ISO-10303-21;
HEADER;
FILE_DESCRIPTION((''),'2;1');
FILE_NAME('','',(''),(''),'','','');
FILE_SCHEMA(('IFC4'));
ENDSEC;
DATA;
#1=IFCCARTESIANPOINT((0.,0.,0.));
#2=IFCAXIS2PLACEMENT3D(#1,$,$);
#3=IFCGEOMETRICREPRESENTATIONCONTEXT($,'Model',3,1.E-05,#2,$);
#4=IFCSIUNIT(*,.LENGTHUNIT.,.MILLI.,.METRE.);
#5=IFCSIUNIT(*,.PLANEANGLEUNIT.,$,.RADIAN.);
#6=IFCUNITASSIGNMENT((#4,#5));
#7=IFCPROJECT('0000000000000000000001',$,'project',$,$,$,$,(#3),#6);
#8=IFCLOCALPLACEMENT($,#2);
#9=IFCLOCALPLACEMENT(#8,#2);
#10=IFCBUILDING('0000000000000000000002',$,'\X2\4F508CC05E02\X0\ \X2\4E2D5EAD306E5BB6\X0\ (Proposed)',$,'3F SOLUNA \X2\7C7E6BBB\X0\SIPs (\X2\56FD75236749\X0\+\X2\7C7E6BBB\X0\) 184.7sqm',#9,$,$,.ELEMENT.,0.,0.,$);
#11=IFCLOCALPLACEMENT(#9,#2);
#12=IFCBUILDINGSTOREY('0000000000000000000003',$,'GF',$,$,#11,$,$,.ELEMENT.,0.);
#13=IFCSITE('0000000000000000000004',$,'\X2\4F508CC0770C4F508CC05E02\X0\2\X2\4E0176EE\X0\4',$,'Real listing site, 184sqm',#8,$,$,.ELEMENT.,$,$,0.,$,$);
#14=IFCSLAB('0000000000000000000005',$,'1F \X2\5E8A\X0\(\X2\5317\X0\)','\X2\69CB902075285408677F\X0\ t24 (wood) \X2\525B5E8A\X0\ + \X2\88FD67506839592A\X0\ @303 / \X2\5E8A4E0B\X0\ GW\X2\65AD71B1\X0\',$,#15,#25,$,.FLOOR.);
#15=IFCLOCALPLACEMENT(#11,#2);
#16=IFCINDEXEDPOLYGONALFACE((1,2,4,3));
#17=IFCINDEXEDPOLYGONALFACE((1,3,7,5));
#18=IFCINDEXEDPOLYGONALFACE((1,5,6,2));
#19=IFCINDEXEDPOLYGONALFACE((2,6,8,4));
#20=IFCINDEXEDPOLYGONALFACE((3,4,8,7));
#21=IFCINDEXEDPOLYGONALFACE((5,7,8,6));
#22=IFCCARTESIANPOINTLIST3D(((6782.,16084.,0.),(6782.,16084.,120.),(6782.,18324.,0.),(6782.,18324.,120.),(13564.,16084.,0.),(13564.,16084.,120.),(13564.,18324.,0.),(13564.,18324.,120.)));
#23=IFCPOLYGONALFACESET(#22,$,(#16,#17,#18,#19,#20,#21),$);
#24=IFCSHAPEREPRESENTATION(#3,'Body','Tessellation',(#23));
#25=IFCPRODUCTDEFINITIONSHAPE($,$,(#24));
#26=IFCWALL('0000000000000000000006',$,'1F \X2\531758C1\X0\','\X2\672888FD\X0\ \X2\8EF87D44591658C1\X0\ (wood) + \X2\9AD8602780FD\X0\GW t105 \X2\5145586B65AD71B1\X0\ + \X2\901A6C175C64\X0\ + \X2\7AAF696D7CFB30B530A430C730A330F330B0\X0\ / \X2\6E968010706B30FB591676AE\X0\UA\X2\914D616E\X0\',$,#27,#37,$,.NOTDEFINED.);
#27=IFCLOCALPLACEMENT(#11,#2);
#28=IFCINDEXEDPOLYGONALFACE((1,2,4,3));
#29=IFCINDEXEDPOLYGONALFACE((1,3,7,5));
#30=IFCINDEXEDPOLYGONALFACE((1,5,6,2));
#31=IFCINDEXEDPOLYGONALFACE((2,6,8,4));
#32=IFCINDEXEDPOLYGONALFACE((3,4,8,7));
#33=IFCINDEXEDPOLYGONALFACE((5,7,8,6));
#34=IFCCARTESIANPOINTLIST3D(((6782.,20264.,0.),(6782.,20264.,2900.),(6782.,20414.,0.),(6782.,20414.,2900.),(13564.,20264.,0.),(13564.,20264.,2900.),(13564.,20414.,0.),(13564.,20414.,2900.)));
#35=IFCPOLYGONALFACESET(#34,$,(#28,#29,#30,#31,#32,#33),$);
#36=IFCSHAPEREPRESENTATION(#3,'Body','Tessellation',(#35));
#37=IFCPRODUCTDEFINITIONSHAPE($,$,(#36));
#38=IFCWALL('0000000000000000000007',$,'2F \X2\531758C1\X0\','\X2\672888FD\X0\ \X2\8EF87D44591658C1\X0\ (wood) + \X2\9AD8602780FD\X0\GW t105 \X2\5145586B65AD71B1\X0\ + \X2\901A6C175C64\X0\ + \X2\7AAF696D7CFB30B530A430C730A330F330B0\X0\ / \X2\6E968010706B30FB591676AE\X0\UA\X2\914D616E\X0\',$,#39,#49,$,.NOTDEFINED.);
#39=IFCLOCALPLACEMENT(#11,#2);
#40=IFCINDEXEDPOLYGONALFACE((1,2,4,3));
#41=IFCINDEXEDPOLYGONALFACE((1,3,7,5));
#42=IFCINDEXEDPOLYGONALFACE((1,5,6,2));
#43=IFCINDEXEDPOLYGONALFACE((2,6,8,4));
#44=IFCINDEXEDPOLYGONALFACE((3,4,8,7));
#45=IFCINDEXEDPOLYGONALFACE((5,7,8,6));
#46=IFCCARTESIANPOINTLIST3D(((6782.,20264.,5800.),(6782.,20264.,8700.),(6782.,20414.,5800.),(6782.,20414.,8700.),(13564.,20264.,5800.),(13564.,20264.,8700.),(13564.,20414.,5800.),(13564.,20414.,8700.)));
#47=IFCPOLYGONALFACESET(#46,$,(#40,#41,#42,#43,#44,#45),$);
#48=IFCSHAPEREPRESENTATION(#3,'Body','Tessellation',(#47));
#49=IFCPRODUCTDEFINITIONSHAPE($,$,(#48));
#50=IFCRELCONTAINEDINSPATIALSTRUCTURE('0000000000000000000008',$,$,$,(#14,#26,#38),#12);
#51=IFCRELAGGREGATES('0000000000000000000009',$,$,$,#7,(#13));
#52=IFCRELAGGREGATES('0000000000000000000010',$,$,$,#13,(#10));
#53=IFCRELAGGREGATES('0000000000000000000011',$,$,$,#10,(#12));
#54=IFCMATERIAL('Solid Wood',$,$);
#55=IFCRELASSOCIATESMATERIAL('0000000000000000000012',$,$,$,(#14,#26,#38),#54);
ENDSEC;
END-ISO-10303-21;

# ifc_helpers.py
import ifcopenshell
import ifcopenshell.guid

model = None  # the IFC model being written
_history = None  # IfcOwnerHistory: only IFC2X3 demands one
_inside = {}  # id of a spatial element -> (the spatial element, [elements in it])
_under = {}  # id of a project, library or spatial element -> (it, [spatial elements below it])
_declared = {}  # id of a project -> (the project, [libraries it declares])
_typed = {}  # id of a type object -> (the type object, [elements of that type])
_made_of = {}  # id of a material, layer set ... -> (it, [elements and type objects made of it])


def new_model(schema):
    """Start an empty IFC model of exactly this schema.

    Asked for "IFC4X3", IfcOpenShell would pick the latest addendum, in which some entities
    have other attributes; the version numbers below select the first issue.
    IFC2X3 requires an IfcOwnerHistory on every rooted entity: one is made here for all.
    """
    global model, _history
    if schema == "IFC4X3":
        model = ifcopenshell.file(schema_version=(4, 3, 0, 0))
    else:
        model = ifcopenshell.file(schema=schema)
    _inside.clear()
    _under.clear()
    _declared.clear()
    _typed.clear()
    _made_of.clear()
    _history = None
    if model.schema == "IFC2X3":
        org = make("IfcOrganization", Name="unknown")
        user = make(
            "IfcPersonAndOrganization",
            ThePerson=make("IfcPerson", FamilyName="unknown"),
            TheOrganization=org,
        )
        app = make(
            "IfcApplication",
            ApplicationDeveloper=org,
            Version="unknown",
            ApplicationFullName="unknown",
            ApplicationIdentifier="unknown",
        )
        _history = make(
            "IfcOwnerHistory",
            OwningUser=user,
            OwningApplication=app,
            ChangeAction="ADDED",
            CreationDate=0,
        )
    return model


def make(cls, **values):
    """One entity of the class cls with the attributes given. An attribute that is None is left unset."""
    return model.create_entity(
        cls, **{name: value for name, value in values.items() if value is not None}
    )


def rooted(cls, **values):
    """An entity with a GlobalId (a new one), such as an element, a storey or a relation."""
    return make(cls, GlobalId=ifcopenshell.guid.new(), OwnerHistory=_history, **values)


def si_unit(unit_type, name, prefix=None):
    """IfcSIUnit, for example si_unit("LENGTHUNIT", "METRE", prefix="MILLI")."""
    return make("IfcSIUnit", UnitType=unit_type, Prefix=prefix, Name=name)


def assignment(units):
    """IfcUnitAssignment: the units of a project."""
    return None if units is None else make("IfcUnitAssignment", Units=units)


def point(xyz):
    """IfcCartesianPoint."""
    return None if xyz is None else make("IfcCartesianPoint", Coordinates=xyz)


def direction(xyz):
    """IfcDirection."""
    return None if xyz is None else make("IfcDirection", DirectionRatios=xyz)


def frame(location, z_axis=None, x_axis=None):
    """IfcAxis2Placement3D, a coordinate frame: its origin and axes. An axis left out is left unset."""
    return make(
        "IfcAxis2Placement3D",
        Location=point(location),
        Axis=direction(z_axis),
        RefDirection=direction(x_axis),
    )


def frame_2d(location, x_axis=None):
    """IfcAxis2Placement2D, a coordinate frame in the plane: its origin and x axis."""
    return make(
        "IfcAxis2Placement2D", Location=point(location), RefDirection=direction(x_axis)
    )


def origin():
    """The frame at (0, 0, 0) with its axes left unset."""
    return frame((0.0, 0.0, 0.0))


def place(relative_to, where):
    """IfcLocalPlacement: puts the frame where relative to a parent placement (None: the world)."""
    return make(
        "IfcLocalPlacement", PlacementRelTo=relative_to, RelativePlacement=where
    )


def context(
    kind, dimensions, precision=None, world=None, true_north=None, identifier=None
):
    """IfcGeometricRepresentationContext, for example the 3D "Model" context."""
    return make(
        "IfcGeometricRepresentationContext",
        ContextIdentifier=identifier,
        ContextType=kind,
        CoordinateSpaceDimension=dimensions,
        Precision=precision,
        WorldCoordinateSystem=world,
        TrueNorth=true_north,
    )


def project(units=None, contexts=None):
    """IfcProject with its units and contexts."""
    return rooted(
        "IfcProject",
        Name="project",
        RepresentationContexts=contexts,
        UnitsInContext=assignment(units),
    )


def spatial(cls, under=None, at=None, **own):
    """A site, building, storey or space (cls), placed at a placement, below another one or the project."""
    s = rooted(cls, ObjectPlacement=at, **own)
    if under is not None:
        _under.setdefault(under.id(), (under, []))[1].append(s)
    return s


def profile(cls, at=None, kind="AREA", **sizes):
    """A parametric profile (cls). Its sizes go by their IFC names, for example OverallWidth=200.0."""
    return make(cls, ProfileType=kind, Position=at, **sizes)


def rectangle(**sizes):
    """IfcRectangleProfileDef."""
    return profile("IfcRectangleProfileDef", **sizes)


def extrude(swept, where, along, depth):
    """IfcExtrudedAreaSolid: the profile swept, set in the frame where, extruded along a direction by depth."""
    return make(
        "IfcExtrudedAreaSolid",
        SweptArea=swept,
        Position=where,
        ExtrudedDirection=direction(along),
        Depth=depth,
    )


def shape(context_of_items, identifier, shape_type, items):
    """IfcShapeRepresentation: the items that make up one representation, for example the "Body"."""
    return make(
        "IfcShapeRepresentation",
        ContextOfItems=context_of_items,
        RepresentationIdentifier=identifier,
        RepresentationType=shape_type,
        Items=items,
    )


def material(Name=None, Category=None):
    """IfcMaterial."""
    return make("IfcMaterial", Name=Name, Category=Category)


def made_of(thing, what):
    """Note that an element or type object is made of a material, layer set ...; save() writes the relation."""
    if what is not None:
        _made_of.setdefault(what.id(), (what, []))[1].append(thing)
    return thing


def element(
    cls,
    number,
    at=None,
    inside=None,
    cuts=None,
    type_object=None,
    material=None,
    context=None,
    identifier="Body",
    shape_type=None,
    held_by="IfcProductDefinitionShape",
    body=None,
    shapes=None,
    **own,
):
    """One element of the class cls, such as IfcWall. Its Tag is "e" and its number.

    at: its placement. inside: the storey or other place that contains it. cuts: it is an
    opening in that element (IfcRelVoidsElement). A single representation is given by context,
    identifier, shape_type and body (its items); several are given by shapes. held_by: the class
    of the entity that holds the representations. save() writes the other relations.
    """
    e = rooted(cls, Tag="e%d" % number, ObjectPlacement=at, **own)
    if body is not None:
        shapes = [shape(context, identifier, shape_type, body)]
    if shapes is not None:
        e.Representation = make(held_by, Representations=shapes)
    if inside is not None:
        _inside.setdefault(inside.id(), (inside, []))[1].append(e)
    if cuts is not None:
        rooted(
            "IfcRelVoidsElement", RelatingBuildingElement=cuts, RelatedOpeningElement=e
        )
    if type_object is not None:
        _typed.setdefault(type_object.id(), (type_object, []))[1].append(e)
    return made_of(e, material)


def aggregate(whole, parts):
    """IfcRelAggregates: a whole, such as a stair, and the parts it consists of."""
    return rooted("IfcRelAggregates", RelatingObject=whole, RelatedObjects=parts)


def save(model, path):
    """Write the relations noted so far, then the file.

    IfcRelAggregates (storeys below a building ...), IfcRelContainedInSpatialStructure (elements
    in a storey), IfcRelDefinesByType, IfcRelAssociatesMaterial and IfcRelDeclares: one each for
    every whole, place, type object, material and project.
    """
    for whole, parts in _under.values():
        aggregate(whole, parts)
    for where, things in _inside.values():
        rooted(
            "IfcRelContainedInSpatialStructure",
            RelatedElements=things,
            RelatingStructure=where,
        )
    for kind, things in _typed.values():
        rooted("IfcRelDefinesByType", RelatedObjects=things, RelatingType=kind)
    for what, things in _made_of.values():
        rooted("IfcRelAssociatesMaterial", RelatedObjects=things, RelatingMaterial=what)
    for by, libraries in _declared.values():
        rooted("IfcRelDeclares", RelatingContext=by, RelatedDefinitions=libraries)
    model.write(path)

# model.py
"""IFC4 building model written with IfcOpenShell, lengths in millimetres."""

from ifc_helpers import new_model, si_unit, frame, frame_2d, origin, place, context, project, spatial, rectangle, extrude, material, element, save


model = new_model("IFC4")

# Units and contexts
model_context = context("Model", 3, precision=1e-05, world=origin())
ifc_project = project(units=[si_unit("LENGTHUNIT", "METRE", prefix="MILLI"), si_unit("PLANEANGLEUNIT", "RADIAN")], contexts=[model_context])

# Site, building, storey
site_placement = place(None, origin())
site = spatial("IfcSite", under=ifc_project, at=site_placement, Name="佐賀県佐賀市2丁目4", ObjectType="Real listing site, 184sqm", CompositionType="ELEMENT", RefElevation=0.0)
building_placement = place(site_placement, origin())
building = spatial("IfcBuilding", under=site, at=building_placement, Name="佐賀市 中庭の家 (Proposed)", ObjectType="3F SOLUNA 籾殻SIPs (国産杉+籾殻) 184.7sqm", CompositionType="ELEMENT", ElevationOfRefHeight=0.0, ElevationOfTerrain=0.0)
storey_placement = place(building_placement, origin())
storey = spatial("IfcBuildingStorey", under=building, at=storey_placement, Name="GF", CompositionType="ELEMENT", Elevation=0.0)

# Slab
ifc_material_1 = material(Name="Solid Wood")
slab_1_placement = place(storey_placement, frame((3391.0, 8042.0, 0.0)))
element("IfcSlab", 1, at=slab_1_placement, inside=storey, material=ifc_material_1, Name="1F 床(北)", Description="構造用合板 t24 (wood) 剛床 + 製材根太 @303 / 床下 GW断熱", PredefinedType="FLOOR", context=model_context, shape_type="SweptSolid", body=[
    extrude(rectangle(XDim=6782.0, YDim=2240.0, at=frame_2d((3391.0, 1120.0))), frame((3391.0, 8042.0, 0.0)), (0.0, 0.0, 1.0), 120.0),
])

# Wall
wall_1_placement = place(storey_placement, frame((3391.0, 10132.0, 0.0)))
element("IfcWall", 2, at=wall_1_placement, inside=storey, material=ifc_material_1, Name="1F 北壁", Description="木製 軸組外壁 (wood) + 高性能GW t105 充填断熱 + 通気層 + 窯業系サイディング / 準耐火・外皮UA配慮", PredefinedType="NOTDEFINED", context=model_context, shape_type="SweptSolid", body=[
    extrude(rectangle(XDim=6782.0, YDim=150.0, at=frame_2d((3391.0, 75.0))), frame((3391.0, 10132.0, 0.0)), (0.0, 0.0, 1.0), 2900.0),
])

# Wall
wall_2_placement = place(storey_placement, frame((3391.0, 10132.0, 2900.0)))
element("IfcWall", 3, at=wall_2_placement, inside=storey, material=ifc_material_1, Name="2F 北壁", Description="木製 軸組外壁 (wood) + 高性能GW t105 充填断熱 + 通気層 + 窯業系サイディング / 準耐火・外皮UA配慮", PredefinedType="NOTDEFINED", context=model_context, shape_type="SweptSolid", body=[
    extrude(rectangle(XDim=6782.0, YDim=150.0, at=frame_2d((3391.0, 75.0))), frame((3391.0, 10132.0, 2900.0)), (0.0, 0.0, 1.0), 2900.0),
])

save(model, "model.ifc")
